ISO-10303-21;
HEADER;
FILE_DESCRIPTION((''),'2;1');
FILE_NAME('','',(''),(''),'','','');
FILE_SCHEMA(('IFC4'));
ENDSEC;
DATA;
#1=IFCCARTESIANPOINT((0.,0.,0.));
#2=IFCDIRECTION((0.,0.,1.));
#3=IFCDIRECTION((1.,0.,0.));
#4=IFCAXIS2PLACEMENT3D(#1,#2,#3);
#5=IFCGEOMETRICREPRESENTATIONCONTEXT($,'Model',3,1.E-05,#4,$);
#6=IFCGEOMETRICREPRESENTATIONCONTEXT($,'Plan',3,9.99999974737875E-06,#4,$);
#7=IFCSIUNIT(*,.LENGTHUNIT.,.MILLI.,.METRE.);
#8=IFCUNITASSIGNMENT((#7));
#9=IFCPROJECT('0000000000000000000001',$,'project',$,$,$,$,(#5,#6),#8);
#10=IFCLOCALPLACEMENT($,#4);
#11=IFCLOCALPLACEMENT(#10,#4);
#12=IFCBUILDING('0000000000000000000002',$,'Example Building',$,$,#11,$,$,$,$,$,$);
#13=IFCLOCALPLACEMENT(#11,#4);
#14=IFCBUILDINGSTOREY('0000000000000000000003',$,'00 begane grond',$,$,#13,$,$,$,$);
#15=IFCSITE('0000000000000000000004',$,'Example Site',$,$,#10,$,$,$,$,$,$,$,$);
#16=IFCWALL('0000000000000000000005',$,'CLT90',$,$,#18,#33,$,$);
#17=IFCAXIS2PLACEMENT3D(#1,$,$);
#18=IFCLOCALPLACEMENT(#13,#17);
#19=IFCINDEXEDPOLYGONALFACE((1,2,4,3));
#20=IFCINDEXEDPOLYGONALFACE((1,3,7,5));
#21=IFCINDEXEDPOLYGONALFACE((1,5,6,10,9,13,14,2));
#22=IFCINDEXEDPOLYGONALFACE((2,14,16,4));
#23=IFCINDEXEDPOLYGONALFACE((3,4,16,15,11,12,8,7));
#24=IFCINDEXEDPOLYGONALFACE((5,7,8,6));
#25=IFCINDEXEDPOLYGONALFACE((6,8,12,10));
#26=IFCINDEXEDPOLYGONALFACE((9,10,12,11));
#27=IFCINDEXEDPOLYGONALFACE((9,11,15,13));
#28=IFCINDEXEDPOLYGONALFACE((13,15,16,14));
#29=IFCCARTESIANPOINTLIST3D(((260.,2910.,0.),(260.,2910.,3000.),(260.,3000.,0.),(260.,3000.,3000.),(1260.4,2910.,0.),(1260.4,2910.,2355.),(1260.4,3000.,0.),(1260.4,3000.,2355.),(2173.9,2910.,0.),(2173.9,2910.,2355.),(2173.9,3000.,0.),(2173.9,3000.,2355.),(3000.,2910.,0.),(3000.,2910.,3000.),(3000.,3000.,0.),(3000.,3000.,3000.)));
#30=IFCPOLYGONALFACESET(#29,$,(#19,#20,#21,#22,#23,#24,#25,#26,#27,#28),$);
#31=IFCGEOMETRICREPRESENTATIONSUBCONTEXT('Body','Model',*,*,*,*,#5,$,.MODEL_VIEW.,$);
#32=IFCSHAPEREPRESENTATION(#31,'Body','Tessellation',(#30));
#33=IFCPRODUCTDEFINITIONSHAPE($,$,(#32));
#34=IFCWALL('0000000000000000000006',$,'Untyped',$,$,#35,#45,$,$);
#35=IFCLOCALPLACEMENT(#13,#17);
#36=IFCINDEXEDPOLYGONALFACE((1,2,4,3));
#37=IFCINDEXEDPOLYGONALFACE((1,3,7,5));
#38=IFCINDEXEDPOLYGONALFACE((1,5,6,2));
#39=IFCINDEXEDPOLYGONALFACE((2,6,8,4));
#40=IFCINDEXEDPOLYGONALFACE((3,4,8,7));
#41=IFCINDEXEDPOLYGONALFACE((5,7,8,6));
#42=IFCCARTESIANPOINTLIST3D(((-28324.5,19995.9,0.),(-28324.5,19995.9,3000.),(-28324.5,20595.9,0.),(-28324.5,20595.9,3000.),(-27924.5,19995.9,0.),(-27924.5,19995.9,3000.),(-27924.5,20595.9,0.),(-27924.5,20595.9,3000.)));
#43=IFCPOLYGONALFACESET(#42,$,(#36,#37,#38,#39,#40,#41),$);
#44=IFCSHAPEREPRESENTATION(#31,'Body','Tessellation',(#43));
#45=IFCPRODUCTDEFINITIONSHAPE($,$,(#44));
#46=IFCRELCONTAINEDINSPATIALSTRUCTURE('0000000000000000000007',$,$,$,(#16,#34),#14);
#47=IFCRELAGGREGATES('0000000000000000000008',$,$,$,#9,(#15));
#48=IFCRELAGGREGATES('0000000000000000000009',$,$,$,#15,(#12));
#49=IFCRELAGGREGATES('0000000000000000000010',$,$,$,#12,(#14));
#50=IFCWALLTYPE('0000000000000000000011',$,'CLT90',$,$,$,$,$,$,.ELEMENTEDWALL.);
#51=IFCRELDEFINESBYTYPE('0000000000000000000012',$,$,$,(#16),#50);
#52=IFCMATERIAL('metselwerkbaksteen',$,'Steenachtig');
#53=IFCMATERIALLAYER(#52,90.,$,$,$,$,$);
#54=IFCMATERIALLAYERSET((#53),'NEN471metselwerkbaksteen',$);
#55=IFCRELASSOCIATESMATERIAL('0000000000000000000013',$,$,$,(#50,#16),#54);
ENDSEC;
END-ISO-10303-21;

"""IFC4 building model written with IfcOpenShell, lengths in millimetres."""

from ifc_helpers import new_model, si_unit, frame, origin_with_axes, place, context, subcontext, project, spatial, line, indexed_curve, outline, extrude, source, transform, mapped, material, layer, layer_set, layer_usage, type_object, element, save


model = new_model("IFC4")

# Units and contexts
model_context = context("Model", 3, precision=1e-05, world=origin_with_axes())
plan_context = context("Plan", 3, precision=9.99999974737875e-06, world=origin_with_axes())
body_context = subcontext(model_context, "Body", "Model", "MODEL_VIEW")
ifc_project = project(units=[si_unit("LENGTHUNIT", "METRE", prefix="MILLI")], contexts=[model_context, plan_context])

# Site, building, storey
site_placement = place(None, frame((0.0, 0.0, 0.0), z_axis=(0.0, 0.0, 1.0), x_axis=(1.0, 0.0, 0.0)))
site = spatial("IfcSite", under=ifc_project, at=site_placement, Name="Example Site")
building_placement = place(site_placement, origin_with_axes())
building = spatial("IfcBuilding", under=site, at=building_placement, Name="Example Building")
storey_placement = place(building_placement, origin_with_axes())
storey = spatial("IfcBuildingStorey", under=building, at=storey_placement, Name="00 begane grond")

# Shared definitions
ifc_material_1 = material(Name="metselwerkbaksteen", Category="Steenachtig")
ifc_layer_1 = layer(ifc_material_1, 90.0)
ifc_layer_set_1 = layer_set([ifc_layer_1], Name="NEN471metselwerkbaksteen")
wall_type_1 = type_object("IfcWallType", Name="CLT90", PredefinedType="ELEMENTEDWALL", material=ifc_layer_set_1)

# Wall, opening
ifc_layer_usage_1 = layer_usage(ifc_layer_set_1, "AXIS2", "POSITIVE", 0.0)
wall_1_placement = place(storey_placement, frame((260.0, 2910.0, 0.0), z_axis=(0.0, 0.0, 1.0), x_axis=(1.0, 0.0, 0.0)))
wall_1 = element("IfcWall", 1, at=wall_1_placement, inside=storey, type_object=wall_type_1, material=ifc_layer_usage_1, Name="CLT90", context=body_context, shape_type="SweptSolid", body=[
    extrude(outline(indexed_curve([(0.0, 0.0), (0.0, 90.0), (2740.0, 90.0), (2740.0, 0.0), (0.0, 0.0)], self_intersect=False)), origin_with_axes(), (0.0, 0.0, 1.0), 3000.0),
])
shared_shape_1 = source(origin_with_axes(), body_context, "Body", "SweptSolid", [
    extrude(outline(indexed_curve([(0.0, 0.0), (913.4, 0.0), (913.4, 2355.0), (0.0, 2355.0)], segments=[line(1, 2, 3, 4, 1)])), frame((0.0, -600.0, 0.0), z_axis=(0.0, -1.0, 0.0), x_axis=(1.0, 0.0, 0.0)), (0.0, 0.0, -1.0), 1200.0),
])
opening_1_placement = place(wall_1_placement, frame((1000.4, 0.0, 0.0), z_axis=(0.0, 0.0, 1.0), x_axis=(1.0, 0.0, 0.0)))
element("IfcOpeningElement", 2, at=opening_1_placement, cuts=wall_1, PredefinedType="OPENING", context=body_context, shape_type="MappedRepresentation", body=[
    mapped(shared_shape_1, transform((0.0, 0.0, 0.0), x_axis=(1.0, 0.0, 0.0), y_axis=(0.0, 1.0, 0.0), z_axis=(0.0, 0.0, 1.0), scale=1.0)),
])

# Wall
wall_2_placement = place(storey_placement, frame((-27924.5, 19995.9, 0.0), z_axis=(0.0, 0.0, 1.0), x_axis=(0.0, 1.0, 0.0)))
element("IfcWall", 3, at=wall_2_placement, inside=storey, Name="Untyped", context=body_context, shape_type="SweptSolid", body=[
    extrude(outline(indexed_curve([(0.0, 0.0), (0.0, 400.0), (600.0, 400.0), (600.0, 0.0), (0.0, 0.0)], self_intersect=False)), origin_with_axes(), (0.0, 0.0, 1.0), 3000.0),
])

save(model, "model.ifc")
